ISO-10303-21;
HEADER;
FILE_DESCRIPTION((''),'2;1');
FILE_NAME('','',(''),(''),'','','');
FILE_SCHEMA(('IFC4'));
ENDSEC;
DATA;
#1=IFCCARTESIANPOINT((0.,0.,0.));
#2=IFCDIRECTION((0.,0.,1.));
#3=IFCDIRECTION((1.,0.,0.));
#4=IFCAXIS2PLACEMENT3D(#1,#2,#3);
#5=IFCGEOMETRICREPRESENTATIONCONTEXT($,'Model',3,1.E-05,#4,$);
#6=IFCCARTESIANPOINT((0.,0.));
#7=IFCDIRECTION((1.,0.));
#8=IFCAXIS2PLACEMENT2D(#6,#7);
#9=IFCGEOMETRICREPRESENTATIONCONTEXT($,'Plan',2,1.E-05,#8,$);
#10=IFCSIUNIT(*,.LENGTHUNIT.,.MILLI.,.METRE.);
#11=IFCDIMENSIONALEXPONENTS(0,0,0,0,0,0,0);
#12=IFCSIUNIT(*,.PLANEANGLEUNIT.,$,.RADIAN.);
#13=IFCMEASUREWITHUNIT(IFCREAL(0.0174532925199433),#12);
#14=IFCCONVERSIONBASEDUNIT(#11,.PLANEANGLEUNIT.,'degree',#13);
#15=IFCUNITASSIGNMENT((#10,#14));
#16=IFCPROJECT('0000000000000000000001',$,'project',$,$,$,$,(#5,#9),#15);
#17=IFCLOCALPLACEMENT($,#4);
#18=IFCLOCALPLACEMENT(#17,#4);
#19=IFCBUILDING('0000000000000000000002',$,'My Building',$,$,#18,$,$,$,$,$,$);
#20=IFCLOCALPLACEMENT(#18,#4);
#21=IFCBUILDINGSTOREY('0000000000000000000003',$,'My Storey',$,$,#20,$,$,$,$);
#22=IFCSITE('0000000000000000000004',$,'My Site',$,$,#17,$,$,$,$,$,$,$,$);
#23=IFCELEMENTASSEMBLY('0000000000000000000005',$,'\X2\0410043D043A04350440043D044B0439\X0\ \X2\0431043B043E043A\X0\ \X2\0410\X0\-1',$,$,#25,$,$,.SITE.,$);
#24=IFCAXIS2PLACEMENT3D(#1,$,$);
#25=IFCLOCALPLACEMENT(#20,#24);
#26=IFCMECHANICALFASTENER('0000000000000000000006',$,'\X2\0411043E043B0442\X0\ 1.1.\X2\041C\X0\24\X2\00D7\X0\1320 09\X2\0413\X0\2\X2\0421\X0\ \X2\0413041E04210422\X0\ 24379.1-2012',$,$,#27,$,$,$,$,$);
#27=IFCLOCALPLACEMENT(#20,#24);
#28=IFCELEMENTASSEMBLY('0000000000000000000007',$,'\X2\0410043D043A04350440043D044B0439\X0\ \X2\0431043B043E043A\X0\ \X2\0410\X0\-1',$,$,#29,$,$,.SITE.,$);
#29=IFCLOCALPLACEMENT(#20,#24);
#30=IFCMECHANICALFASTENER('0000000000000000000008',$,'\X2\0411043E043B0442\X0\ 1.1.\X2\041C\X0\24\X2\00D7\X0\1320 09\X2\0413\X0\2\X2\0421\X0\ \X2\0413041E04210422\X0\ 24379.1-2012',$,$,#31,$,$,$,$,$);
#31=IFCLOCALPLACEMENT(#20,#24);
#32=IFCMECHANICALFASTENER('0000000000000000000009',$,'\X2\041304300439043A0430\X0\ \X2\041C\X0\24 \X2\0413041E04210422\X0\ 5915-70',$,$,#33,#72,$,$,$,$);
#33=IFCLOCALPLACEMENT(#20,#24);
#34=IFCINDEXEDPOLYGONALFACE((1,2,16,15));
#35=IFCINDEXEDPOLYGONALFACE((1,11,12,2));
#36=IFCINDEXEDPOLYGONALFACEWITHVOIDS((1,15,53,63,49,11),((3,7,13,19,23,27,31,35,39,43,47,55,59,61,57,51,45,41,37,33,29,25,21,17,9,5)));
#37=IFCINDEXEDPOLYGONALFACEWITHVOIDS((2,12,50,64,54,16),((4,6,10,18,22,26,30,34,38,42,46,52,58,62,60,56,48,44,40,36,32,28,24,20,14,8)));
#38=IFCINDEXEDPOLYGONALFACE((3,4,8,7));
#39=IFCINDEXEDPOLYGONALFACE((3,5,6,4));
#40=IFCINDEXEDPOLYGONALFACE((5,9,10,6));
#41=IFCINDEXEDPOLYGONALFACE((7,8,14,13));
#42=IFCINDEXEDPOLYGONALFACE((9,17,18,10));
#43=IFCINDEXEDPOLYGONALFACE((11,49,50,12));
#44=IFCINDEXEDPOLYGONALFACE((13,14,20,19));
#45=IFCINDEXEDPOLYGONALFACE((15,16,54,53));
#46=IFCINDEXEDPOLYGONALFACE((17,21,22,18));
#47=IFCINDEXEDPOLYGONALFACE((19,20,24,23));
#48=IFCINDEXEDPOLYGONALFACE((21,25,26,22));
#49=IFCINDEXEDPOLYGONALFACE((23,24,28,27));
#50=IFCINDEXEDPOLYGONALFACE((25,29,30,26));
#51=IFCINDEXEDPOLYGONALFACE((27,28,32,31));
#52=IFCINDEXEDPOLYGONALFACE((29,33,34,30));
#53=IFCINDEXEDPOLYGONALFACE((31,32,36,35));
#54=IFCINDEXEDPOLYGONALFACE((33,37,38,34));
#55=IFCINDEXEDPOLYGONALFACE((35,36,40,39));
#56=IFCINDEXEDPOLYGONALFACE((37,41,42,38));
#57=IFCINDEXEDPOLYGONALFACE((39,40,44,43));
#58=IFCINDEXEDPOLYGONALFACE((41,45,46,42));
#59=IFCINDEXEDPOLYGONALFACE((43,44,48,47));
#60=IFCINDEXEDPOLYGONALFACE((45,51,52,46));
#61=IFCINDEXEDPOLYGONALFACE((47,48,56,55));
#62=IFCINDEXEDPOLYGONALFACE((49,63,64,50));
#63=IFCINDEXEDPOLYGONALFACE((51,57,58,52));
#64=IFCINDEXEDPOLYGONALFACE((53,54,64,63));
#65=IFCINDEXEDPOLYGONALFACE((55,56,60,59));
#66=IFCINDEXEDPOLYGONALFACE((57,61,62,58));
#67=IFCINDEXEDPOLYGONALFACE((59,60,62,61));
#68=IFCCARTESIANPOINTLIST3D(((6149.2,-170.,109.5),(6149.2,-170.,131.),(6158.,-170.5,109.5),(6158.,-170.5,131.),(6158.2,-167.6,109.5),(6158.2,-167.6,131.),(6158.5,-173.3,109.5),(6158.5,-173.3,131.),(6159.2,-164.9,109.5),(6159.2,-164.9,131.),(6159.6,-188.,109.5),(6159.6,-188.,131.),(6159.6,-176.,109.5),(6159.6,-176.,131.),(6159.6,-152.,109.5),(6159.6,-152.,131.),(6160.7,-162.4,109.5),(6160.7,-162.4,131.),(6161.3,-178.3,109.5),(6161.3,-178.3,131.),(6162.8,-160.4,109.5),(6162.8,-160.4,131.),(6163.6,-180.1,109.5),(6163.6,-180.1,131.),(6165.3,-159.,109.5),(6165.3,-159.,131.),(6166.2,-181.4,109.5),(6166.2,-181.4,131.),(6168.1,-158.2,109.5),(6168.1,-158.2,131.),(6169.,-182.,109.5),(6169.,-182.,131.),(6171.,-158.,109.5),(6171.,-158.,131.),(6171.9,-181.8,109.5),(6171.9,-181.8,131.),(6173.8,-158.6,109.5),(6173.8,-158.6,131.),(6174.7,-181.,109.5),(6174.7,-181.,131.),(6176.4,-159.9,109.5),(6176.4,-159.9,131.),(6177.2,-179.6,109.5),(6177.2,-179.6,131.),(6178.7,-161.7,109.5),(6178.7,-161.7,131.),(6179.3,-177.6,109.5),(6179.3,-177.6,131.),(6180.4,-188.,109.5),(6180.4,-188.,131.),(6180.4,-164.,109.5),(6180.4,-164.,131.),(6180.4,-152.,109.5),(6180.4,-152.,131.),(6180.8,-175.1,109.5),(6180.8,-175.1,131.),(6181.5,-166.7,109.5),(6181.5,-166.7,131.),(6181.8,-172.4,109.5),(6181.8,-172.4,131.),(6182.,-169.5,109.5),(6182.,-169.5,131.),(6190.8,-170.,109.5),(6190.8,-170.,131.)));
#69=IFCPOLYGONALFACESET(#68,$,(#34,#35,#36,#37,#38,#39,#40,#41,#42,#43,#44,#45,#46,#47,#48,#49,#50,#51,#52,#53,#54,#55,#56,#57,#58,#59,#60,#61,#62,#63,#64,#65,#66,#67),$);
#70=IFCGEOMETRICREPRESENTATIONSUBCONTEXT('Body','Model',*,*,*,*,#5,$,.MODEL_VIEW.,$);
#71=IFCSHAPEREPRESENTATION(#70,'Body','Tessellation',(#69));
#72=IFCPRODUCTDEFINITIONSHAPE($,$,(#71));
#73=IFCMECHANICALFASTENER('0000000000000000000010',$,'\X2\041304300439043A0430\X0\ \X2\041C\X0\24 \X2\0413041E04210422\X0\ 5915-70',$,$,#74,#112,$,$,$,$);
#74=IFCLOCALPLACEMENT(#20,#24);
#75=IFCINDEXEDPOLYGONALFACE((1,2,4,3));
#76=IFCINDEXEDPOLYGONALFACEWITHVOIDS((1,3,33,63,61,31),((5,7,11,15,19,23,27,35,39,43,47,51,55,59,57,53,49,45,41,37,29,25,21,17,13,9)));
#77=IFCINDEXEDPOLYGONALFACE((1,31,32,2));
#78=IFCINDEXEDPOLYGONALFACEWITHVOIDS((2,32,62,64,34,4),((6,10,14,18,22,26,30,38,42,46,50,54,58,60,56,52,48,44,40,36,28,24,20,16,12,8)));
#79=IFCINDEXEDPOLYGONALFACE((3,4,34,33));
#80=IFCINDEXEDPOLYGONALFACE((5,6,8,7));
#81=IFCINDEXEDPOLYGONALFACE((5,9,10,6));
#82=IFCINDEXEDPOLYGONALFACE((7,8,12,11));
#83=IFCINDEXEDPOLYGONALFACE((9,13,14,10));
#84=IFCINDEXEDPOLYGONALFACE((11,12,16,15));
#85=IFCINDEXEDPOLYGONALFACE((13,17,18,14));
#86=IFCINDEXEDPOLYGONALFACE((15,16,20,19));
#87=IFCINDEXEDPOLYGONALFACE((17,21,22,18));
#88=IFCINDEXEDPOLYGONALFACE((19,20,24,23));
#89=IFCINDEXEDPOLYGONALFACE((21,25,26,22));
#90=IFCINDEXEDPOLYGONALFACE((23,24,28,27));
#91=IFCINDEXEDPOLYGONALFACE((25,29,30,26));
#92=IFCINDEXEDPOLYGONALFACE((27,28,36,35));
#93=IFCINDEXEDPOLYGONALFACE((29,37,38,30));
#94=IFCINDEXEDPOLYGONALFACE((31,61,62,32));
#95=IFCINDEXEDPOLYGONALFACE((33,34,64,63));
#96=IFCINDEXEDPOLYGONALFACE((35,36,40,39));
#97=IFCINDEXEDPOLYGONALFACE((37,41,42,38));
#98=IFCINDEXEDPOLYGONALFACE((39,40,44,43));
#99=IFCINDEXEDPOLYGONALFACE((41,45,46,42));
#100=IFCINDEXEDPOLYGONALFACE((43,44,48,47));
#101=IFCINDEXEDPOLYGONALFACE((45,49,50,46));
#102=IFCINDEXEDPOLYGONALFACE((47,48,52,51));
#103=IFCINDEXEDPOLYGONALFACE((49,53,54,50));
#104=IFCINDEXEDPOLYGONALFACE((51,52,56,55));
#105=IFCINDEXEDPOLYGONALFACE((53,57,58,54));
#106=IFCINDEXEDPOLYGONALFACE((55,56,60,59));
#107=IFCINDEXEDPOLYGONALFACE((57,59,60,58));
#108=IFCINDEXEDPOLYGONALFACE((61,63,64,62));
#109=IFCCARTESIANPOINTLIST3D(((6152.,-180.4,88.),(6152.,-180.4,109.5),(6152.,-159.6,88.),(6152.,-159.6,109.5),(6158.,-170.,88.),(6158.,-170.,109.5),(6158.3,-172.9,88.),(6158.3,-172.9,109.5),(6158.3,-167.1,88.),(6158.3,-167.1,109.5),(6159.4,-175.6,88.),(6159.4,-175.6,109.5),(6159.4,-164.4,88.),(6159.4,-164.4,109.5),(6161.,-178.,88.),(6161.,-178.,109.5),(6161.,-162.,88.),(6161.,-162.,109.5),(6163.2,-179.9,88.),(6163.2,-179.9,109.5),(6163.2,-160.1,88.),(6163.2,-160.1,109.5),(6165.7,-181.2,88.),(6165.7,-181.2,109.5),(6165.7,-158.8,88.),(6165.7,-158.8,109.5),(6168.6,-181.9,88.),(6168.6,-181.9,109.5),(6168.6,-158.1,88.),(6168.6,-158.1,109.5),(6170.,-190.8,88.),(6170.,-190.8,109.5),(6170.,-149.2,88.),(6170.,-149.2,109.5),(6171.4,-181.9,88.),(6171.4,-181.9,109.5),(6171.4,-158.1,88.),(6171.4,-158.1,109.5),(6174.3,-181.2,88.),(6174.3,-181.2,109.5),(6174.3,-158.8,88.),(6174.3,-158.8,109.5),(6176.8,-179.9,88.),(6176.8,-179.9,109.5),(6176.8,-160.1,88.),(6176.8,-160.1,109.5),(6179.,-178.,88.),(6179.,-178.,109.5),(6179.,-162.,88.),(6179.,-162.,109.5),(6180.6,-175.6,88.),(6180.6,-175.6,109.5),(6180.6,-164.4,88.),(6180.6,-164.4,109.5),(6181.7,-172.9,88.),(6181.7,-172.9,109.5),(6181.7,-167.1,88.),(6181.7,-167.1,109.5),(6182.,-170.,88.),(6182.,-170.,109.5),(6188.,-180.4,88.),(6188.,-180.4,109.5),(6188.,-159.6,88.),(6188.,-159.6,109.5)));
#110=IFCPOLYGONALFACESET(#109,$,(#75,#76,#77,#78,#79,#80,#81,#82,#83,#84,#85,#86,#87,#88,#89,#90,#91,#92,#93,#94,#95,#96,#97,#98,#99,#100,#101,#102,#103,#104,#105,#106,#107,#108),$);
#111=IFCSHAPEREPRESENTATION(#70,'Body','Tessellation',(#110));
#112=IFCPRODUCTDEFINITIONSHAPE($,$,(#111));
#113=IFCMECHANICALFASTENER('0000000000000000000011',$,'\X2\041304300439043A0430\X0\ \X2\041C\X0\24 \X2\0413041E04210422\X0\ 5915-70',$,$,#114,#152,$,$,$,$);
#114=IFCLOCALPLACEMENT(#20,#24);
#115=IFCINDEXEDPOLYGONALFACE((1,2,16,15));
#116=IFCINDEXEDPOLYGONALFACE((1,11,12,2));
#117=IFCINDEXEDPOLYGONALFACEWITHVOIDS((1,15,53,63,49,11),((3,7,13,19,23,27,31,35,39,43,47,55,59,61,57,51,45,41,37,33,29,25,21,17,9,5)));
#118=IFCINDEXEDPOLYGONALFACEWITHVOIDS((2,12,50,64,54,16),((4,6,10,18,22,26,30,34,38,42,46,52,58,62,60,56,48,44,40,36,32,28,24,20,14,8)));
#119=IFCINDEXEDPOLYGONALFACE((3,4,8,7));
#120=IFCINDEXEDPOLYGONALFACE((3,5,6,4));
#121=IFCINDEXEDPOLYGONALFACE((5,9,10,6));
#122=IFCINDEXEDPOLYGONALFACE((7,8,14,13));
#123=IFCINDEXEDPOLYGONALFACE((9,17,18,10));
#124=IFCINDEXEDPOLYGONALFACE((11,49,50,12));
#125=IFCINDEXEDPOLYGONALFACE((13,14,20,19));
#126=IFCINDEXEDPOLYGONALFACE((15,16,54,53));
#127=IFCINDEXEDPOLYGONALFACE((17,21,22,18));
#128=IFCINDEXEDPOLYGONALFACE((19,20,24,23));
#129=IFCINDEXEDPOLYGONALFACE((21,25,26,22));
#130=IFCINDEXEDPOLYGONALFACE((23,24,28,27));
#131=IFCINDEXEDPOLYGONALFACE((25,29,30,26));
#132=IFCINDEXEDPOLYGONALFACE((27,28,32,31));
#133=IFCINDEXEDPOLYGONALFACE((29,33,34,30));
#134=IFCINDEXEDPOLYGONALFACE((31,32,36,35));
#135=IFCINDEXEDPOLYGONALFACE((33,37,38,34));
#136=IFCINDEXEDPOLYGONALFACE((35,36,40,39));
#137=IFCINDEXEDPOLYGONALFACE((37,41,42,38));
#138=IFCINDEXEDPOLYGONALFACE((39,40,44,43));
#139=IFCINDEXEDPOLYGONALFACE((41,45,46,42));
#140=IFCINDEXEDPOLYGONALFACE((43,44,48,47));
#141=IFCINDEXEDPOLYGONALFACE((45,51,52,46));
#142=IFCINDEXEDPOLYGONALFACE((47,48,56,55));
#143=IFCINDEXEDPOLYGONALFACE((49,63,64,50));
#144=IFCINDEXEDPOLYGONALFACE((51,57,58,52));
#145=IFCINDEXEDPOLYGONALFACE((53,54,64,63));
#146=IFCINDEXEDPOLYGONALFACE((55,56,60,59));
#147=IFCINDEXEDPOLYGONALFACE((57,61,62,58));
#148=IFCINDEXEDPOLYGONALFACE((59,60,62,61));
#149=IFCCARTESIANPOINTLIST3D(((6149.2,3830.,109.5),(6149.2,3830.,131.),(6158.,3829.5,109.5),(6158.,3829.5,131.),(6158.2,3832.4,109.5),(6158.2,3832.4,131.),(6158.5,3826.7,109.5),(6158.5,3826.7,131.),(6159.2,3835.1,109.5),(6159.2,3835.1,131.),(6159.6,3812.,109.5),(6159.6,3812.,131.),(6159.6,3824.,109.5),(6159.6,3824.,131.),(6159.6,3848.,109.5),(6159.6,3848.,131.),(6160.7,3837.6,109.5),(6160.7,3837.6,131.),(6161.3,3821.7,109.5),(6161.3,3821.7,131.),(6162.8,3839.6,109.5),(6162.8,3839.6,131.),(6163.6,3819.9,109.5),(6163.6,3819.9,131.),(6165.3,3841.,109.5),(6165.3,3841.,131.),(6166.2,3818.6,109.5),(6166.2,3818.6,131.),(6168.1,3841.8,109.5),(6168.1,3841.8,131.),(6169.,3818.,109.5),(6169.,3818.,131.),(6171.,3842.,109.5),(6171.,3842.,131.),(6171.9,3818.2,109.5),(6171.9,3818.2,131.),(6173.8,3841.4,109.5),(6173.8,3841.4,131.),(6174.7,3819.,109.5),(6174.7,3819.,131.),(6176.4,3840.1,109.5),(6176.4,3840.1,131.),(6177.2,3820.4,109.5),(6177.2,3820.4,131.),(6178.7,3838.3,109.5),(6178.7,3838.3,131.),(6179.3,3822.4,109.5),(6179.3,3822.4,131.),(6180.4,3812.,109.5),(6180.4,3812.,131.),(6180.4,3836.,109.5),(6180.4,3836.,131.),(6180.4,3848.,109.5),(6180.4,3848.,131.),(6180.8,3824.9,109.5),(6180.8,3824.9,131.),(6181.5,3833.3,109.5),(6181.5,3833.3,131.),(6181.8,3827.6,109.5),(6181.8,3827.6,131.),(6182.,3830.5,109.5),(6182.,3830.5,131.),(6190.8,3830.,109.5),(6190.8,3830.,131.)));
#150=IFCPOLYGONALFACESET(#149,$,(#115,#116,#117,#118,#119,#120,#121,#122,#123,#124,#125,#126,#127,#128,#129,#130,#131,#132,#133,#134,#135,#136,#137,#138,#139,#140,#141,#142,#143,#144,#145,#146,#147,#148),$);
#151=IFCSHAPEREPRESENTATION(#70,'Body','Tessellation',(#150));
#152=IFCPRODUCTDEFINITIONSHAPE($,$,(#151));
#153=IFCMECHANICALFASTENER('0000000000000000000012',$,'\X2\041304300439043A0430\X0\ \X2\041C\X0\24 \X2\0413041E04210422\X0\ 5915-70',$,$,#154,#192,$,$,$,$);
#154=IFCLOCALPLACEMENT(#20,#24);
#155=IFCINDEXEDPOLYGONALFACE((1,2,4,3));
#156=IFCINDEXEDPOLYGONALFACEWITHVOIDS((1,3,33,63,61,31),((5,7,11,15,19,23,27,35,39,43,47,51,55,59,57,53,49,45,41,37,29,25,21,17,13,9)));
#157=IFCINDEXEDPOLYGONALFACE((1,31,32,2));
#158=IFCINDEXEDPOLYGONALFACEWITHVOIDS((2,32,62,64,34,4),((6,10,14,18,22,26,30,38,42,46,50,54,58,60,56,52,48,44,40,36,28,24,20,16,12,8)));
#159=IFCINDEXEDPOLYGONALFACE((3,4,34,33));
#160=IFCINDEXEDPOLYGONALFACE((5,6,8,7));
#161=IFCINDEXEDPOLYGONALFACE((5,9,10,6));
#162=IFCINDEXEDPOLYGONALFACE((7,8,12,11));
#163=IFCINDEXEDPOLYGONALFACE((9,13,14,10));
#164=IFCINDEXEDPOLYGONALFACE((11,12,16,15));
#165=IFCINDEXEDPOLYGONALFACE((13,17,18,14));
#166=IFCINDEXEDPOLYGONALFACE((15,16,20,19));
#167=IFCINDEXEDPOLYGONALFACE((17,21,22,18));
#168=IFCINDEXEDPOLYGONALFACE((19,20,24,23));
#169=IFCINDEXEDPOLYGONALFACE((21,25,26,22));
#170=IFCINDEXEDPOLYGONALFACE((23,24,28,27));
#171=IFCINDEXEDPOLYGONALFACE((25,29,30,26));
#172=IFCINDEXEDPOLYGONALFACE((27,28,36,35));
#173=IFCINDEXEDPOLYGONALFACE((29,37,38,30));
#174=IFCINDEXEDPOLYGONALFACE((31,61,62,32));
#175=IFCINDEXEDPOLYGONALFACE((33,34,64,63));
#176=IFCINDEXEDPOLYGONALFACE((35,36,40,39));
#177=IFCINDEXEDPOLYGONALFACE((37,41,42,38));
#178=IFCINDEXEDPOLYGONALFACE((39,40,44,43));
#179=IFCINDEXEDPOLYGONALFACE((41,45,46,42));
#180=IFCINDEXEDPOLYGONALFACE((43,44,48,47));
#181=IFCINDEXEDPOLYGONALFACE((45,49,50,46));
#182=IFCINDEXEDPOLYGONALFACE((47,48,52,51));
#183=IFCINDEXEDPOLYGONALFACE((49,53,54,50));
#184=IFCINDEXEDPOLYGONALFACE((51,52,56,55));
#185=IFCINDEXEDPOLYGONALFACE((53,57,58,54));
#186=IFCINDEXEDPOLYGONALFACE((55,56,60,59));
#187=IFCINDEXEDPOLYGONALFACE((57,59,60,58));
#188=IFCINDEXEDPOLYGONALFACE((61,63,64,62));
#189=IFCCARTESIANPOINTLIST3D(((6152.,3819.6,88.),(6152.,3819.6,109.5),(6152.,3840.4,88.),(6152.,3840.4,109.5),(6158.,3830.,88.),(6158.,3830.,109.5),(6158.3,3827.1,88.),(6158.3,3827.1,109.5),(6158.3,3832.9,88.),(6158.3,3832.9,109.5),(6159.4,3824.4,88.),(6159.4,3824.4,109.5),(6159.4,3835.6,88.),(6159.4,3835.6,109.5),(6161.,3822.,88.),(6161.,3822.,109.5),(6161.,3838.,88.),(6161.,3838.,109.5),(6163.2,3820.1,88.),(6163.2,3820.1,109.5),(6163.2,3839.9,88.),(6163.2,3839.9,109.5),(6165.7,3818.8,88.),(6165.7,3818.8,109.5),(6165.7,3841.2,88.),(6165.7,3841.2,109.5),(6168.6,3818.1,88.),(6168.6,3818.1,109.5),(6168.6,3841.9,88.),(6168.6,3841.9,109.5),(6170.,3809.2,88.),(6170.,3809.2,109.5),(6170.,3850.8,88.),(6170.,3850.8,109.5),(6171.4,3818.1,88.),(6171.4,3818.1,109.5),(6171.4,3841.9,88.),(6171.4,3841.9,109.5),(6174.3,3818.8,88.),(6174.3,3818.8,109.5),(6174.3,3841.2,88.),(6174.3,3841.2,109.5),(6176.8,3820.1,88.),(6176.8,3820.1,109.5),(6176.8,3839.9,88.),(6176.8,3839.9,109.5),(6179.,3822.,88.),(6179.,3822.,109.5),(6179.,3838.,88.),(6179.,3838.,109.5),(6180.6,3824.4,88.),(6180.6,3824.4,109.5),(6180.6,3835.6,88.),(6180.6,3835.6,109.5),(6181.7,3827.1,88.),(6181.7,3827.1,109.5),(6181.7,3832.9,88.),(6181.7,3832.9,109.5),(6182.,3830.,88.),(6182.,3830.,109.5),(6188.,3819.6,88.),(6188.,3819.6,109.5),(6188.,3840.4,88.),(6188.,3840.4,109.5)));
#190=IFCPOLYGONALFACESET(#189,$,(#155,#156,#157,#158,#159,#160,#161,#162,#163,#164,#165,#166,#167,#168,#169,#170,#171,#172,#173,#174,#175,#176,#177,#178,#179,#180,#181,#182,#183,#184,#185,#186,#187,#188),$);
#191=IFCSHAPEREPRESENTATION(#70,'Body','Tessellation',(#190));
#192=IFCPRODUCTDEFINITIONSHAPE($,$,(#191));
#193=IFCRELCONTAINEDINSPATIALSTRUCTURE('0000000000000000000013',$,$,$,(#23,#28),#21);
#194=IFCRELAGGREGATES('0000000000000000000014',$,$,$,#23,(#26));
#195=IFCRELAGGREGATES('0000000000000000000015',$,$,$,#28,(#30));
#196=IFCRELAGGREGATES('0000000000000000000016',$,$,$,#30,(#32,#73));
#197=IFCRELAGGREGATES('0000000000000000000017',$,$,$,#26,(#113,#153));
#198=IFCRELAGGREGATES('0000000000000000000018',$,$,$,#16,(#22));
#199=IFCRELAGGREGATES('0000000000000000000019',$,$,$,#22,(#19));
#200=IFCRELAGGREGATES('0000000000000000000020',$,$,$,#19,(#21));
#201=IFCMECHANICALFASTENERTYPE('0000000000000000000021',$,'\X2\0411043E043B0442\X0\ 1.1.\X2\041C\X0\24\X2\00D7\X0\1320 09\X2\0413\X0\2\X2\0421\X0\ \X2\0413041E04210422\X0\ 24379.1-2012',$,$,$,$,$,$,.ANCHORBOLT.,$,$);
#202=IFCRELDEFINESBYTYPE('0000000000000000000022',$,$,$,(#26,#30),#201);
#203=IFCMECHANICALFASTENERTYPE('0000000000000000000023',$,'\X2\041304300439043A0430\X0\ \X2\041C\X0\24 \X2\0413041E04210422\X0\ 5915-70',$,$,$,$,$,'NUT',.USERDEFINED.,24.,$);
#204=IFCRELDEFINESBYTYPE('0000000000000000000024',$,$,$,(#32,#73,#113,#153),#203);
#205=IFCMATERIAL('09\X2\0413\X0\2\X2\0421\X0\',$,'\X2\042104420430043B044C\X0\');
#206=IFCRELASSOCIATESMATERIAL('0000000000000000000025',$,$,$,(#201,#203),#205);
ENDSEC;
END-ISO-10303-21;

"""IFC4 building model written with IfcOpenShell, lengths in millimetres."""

from ifc_helpers import new_model, entity, si_unit, converted_unit, frame, origin_with_axes, origin_2d_with_axis, place, context, subcontext, project, spatial, polyline, outline, extrude, source, transform, mapped, material, type_object, type_shapes, element, aggregate, save


model = new_model("IFC4")

# Units and contexts
model_context = context("Model", 3, precision=1e-05, world=origin_with_axes())
plan_context = context("Plan", 2, precision=1e-05, world=origin_2d_with_axis())
body_context = subcontext(model_context, "Body", "Model", "MODEL_VIEW")
ifc_project = project(units=[si_unit("LENGTHUNIT", "METRE", prefix="MILLI"), converted_unit("PLANEANGLEUNIT", "degree", entity("IfcReal", 0.0174532925199433), si_unit("PLANEANGLEUNIT", "RADIAN"), dimensions=[0, 0, 0, 0, 0, 0, 0])], contexts=[model_context, plan_context])

# Site, building, storey
site_placement = place(None, origin_with_axes())
site = spatial("IfcSite", under=ifc_project, at=site_placement, Name="My Site")
building_placement = place(site_placement, origin_with_axes())
building = spatial("IfcBuilding", under=site, at=building_placement, Name="My Building")
storey_placement = place(building_placement, origin_with_axes())
storey = spatial("IfcBuildingStorey", under=building, at=storey_placement, Name="My Storey")

# Element assemblies, mechanical fasteners
assembly_1_placement = place(storey_placement, frame((6000.0, 4000.0, 0.0), z_axis=(0.0, 0.0, 1.0), x_axis=(1.0, 0.0, 0.0)))
assembly_1 = element("IfcElementAssembly", 1, at=assembly_1_placement, inside=storey, Name="Анкерный блок А-1", AssemblyPlace="SITE")
ifc_material_1 = material(Name="09Г2С", Category="Сталь")
mechanical_fastener_type_1 = type_object("IfcMechanicalFastenerType", Name="Болт 1.1.М24×1320 09Г2С ГОСТ 24379.1-2012", PredefinedType="ANCHORBOLT", material=ifc_material_1)
mechanical_fastener_1_placement = place(assembly_1_placement, frame((170.0, -170.0, 0.0), z_axis=(0.0, 0.0, 1.0), x_axis=(1.0, 0.0, 0.0)))
mechanical_fastener_1 = element("IfcMechanicalFastener", 2, at=mechanical_fastener_1_placement, type_object=mechanical_fastener_type_1, Name="Болт 1.1.М24×1320 09Г2С ГОСТ 24379.1-2012")
aggregate(assembly_1, [mechanical_fastener_1])
assembly_2_placement = place(storey_placement, frame((6000.0, 0.0, 0.0), z_axis=(0.0, 0.0, 1.0), x_axis=(1.0, 0.0, 0.0)))
assembly_2 = element("IfcElementAssembly", 3, at=assembly_2_placement, inside=storey, Name="Анкерный блок А-1", AssemblyPlace="SITE")
mechanical_fastener_2_placement = place(assembly_2_placement, frame((170.0, -170.0, 0.0), z_axis=(0.0, 0.0, 1.0), x_axis=(1.0, 0.0, 0.0)))
mechanical_fastener_2 = element("IfcMechanicalFastener", 4, at=mechanical_fastener_2_placement, type_object=mechanical_fastener_type_1, Name="Болт 1.1.М24×1320 09Г2С ГОСТ 24379.1-2012")
aggregate(assembly_2, [mechanical_fastener_2])
mechanical_fastener_type_2 = type_object("IfcMechanicalFastenerType", Name="Гайка М24 ГОСТ 5915-70", ElementType="NUT", NominalDiameter=24.0, PredefinedType="USERDEFINED", material=ifc_material_1)
shared_shape_1 = source(origin_with_axes(), body_context, "Body", "SweptSolid", [
    extrude(outline(polyline([(-10.4, -18.0), (10.4, -18.0), (20.8, 0.0), (10.4, 18.0), (-10.4, 18.0), (-20.8, 0.0), (-10.4, -18.0)]), holes=[polyline([(-8.0, 9.0), (-5.6, 10.6), (-2.9, 11.7), (0.0, 12.0), (2.9, 11.7), (5.6, 10.6), (8.0, 9.0), (9.9, 6.8), (11.2, 4.3), (11.9, 1.4), (11.9, -1.4), (11.2, -4.3), (9.9, -6.8), (8.0, -9.0), (5.6, -10.6), (2.9, -11.7), (0.0, -12.0), (-2.9, -11.7), (-5.6, -10.6), (-8.0, -9.0), (-9.9, -6.8), (-11.2, -4.3), (-11.9, -1.4), (-11.9, 1.4), (-11.2, 4.3), (-9.9, 6.8), (-8.0, 9.0)])]), frame((0.0, 0.0, 0.0), z_axis=(0.0, 0.0, 1.0), x_axis=(0.0, 1.0, 0.0)), (0.0, 0.0, 1.0), 21.5),
])
type_shapes(mechanical_fastener_type_2, [shared_shape_1])
mechanical_fastener_3_placement = place(mechanical_fastener_2_placement, frame((0.0, 0.0, 109.5), z_axis=(0.0, 0.0, 1.0), x_axis=(0.866025, 0.5, 0.0)))
mechanical_fastener_3 = element("IfcMechanicalFastener", 5, at=mechanical_fastener_3_placement, type_object=mechanical_fastener_type_2, Name="Гайка М24 ГОСТ 5915-70", context=body_context, shape_type="MappedRepresentation", body=[
    mapped(shared_shape_1, transform((0.0, 0.0, 0.0), x_axis=(1.0, 0.0, 0.0), y_axis=(0.0, 1.0, 0.0), z_axis=(0.0, 0.0, 1.0), scale=1.0)),
])
mechanical_fastener_4_placement = place(mechanical_fastener_2_placement, frame((0.0, 0.0, 88.0), z_axis=(0.0, 0.0, 1.0), x_axis=(1.0, 0.0, 0.0)))
mechanical_fastener_4 = element("IfcMechanicalFastener", 6, at=mechanical_fastener_4_placement, type_object=mechanical_fastener_type_2, Name="Гайка М24 ГОСТ 5915-70", context=body_context, shape_type="MappedRepresentation", body=[
    mapped(shared_shape_1, transform((0.0, 0.0, 0.0), x_axis=(1.0, 0.0, 0.0), y_axis=(0.0, 1.0, 0.0), z_axis=(0.0, 0.0, 1.0), scale=1.0)),
])

# Mechanical fasteners
mechanical_fastener_5_placement = place(mechanical_fastener_1_placement, frame((0.0, 0.0, 109.5), z_axis=(0.0, 0.0, 1.0), x_axis=(0.866025, 0.5, 0.0)))
mechanical_fastener_5 = element("IfcMechanicalFastener", 7, at=mechanical_fastener_5_placement, type_object=mechanical_fastener_type_2, Name="Гайка М24 ГОСТ 5915-70", context=body_context, shape_type="MappedRepresentation", body=[
    mapped(shared_shape_1, transform((0.0, 0.0, 0.0), x_axis=(1.0, 0.0, 0.0), y_axis=(0.0, 1.0, 0.0), z_axis=(0.0, 0.0, 1.0), scale=1.0)),
])
mechanical_fastener_6_placement = place(mechanical_fastener_1_placement, frame((0.0, 0.0, 88.0), z_axis=(0.0, 0.0, 1.0), x_axis=(1.0, 0.0, 0.0)))
mechanical_fastener_6 = element("IfcMechanicalFastener", 8, at=mechanical_fastener_6_placement, type_object=mechanical_fastener_type_2, Name="Гайка М24 ГОСТ 5915-70", context=body_context, shape_type="MappedRepresentation", body=[
    mapped(shared_shape_1, transform((0.0, 0.0, 0.0), x_axis=(1.0, 0.0, 0.0), y_axis=(0.0, 1.0, 0.0), z_axis=(0.0, 0.0, 1.0), scale=1.0)),
])
aggregate(mechanical_fastener_2, [mechanical_fastener_3, mechanical_fastener_4])
aggregate(mechanical_fastener_1, [mechanical_fastener_5, mechanical_fastener_6])

save(model, "model.ifc")
